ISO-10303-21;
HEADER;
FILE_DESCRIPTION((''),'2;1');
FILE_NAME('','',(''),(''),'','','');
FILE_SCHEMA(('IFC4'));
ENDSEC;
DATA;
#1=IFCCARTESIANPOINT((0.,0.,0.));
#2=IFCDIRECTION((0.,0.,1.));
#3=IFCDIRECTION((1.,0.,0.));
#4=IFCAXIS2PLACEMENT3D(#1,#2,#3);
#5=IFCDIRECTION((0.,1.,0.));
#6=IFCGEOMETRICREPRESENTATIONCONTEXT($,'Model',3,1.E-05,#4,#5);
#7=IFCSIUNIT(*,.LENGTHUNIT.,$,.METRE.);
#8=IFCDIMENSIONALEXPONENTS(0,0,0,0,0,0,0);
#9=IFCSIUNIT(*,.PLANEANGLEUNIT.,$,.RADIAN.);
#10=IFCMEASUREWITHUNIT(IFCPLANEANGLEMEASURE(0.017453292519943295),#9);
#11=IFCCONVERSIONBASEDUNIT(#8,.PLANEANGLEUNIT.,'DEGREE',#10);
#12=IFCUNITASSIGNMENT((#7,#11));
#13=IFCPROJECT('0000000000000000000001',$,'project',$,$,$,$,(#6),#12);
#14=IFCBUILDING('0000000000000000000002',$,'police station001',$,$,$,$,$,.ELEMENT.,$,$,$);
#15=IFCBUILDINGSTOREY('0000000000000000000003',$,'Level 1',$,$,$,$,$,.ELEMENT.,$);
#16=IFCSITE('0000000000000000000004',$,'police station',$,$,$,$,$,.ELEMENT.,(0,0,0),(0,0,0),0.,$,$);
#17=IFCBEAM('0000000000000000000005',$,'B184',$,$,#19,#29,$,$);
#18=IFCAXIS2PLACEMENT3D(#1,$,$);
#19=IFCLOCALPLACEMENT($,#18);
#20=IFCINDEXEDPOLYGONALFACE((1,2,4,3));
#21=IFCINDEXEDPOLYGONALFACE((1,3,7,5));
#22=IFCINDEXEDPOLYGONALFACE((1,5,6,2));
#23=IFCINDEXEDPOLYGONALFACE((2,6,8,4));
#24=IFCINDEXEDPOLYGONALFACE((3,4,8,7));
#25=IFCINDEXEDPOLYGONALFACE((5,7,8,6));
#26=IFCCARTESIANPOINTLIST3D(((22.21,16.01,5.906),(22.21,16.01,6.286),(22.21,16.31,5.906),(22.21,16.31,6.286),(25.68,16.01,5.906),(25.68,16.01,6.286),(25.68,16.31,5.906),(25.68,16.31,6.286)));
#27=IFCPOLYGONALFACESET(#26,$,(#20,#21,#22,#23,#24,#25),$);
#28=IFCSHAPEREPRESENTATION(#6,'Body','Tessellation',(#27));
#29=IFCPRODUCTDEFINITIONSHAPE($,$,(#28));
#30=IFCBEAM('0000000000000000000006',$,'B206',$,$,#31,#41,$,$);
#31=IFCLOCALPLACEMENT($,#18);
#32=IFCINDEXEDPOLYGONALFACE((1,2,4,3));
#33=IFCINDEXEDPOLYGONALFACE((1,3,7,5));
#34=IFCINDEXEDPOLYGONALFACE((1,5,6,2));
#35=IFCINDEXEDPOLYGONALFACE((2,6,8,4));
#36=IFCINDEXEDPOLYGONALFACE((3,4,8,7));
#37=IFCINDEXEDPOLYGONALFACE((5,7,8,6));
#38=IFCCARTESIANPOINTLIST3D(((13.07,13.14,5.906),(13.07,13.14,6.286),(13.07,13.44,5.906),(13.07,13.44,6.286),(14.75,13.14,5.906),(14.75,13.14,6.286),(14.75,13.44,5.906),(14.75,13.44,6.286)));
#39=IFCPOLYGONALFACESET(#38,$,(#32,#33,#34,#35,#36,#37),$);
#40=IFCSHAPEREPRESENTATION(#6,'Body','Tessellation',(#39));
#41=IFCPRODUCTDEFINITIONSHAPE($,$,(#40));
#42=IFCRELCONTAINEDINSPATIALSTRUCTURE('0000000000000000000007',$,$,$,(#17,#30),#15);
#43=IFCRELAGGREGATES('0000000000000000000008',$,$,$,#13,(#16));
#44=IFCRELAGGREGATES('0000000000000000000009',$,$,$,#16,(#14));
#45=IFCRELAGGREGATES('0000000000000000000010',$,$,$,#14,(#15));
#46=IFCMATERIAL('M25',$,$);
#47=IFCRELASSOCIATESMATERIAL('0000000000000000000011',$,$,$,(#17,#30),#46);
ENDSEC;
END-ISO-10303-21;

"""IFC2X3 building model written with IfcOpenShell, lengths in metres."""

from ifc_helpers import new_model, entity, si_unit, converted_unit, direction, frame, frame_2d, origin_with_axes, place, context, project, spatial, rectangle, extrude, material, element, save


model = new_model("IFC2X3")

# Units and contexts
model_context = context("Model", 3, precision=1e-05, world=origin_with_axes(), true_north=direction((0.0, 1.0, 0.0)))
ifc_project = project(units=[si_unit("LENGTHUNIT", "METRE"), converted_unit("PLANEANGLEUNIT", "DEGREE", entity("IfcPlaneAngleMeasure", 0.017453292519943295), si_unit("PLANEANGLEUNIT", "RADIAN"), dimensions=[0, 0, 0, 0, 0, 0, 0])], contexts=[model_context])

# Site, building, storey
site = spatial("IfcSite", under=ifc_project, Name="police station", CompositionType="ELEMENT", RefLatitude=(0, 0, 0), RefLongitude=(0, 0, 0), RefElevation=0.0)
building = spatial("IfcBuilding", under=site, Name="police station001", CompositionType="ELEMENT")
storey = spatial("IfcBuildingStorey", under=building, Name="Level 1", CompositionType="ELEMENT")

# Shared definitions
ifc_material = material(Name="M25")
placement = place(None, origin_with_axes())

# Beams
element("IfcBeam", 1, at=placement, inside=storey, material=ifc_material, Name="B184", context=model_context, shape_type="SweptSolid", body=[
    extrude(rectangle(XDim=0.3, YDim=0.38, at=frame_2d((0.0, 0.0), x_axis=(0.0, 1.0, 0.0))), frame((22.21, 16.16, 6.096), z_axis=(1.0, 0.0, 0.0), x_axis=(0.0, 0.0, -1.0)), (0.0, 0.0, 1.0), 3.47),
])
element("IfcBeam", 2, at=placement, inside=storey, material=ifc_material, Name="B206", context=model_context, shape_type="SweptSolid", body=[
    extrude(rectangle(XDim=0.3, YDim=0.38, at=frame_2d((0.0, 0.0), x_axis=(0.0, 1.0, 0.0))), frame((13.07, 13.29, 6.096), z_axis=(1.0, 0.0, 0.0), x_axis=(0.0, 0.0, -1.0)), (0.0, 0.0, 1.0), 1.68),
])

save(model, "model.ifc")
